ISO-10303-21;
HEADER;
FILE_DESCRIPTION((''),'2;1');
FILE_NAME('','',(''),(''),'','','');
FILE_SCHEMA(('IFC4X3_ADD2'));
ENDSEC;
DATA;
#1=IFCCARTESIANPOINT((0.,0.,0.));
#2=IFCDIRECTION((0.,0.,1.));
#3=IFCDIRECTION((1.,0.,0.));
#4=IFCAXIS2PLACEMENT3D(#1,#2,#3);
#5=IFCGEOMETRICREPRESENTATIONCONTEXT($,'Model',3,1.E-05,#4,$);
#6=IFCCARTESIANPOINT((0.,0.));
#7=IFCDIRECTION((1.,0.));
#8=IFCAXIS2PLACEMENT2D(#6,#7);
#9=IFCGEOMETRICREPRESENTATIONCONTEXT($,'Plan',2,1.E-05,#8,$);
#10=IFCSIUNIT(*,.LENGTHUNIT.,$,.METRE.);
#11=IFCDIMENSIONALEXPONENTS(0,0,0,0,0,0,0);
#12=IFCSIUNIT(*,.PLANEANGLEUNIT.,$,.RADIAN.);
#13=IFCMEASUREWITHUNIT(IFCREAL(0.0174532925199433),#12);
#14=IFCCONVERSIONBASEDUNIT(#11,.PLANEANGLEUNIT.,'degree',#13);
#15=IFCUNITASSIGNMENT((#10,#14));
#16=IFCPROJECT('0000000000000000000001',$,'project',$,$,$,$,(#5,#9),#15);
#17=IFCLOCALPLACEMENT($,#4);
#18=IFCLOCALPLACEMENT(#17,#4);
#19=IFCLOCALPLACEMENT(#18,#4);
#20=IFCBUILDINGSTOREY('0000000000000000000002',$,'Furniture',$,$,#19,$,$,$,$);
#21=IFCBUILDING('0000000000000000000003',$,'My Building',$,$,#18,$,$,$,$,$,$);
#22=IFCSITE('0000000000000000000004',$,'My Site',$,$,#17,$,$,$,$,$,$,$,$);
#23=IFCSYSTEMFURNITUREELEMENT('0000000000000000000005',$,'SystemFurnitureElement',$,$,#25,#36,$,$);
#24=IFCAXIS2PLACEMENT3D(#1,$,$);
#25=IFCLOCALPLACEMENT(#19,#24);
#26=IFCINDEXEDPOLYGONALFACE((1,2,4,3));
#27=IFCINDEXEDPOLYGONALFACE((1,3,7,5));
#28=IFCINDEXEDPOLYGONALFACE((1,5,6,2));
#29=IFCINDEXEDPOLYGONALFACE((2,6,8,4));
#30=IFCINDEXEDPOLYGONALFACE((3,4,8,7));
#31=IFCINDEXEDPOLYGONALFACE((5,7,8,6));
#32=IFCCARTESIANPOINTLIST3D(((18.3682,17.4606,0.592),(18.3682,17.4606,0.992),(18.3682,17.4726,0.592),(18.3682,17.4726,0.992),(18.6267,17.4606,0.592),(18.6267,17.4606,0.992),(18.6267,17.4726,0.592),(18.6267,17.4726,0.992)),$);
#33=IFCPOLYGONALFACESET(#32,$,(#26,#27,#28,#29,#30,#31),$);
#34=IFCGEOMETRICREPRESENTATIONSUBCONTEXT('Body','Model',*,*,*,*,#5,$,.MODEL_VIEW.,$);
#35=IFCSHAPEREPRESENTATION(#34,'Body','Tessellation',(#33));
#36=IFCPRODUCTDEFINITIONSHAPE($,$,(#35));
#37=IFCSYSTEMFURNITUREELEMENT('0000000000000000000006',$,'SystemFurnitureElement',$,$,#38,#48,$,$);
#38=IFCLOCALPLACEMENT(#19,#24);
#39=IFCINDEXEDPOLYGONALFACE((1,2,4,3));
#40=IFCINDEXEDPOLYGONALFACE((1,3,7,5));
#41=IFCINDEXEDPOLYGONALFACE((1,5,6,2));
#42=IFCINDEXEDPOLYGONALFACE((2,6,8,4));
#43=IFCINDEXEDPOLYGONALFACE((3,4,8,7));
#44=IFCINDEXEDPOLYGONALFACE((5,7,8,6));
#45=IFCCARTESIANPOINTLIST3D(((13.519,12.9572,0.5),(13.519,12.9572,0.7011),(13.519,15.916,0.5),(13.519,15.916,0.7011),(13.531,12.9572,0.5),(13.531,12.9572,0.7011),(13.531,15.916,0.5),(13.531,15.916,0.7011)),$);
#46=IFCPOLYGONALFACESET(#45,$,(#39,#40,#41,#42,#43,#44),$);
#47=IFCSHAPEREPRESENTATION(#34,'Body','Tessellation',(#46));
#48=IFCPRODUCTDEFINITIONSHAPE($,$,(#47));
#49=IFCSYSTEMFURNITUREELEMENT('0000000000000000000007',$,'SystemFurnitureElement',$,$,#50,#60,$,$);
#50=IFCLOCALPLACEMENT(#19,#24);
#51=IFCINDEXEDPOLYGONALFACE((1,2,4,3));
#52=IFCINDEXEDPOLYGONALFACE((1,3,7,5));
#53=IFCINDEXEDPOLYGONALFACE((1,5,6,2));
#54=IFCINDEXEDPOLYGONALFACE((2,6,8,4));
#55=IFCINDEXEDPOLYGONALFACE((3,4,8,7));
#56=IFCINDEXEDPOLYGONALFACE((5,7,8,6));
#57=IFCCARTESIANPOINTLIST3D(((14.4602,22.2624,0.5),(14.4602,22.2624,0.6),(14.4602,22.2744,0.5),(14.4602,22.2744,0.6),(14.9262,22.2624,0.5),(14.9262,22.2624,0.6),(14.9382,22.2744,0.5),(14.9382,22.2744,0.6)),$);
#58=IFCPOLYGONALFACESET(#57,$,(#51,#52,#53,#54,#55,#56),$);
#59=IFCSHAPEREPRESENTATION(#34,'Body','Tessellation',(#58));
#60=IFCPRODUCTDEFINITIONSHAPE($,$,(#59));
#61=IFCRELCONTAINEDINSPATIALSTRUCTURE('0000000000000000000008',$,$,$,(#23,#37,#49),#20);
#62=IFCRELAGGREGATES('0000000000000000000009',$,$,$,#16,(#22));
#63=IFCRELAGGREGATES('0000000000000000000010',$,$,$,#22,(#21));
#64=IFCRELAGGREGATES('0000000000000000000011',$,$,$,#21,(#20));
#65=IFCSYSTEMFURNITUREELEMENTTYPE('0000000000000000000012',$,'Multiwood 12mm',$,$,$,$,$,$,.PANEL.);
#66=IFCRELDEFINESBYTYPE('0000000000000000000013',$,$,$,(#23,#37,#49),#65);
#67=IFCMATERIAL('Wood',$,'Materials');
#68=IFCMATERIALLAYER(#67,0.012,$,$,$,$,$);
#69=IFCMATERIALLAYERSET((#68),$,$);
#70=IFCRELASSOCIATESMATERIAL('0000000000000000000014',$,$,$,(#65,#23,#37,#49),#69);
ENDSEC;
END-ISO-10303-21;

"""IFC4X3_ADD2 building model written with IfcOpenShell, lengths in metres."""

from ifc_helpers import new_model, entity, si_unit, converted_unit, frame, origin_with_axes, origin_2d_with_axis, place, context, subcontext, project, spatial, line, indexed_curve, outline, extrude, material, layer, layer_set, layer_usage, type_object, element, save


model = new_model("IFC4X3_ADD2")

# Units and contexts
model_context = context("Model", 3, precision=1e-05, world=origin_with_axes())
plan_context = context("Plan", 2, precision=1e-05, world=origin_2d_with_axis())
body_context = subcontext(model_context, "Body", "Model", "MODEL_VIEW")
ifc_project = project(units=[si_unit("LENGTHUNIT", "METRE"), converted_unit("PLANEANGLEUNIT", "degree", entity("IfcReal", 0.0174532925199433), si_unit("PLANEANGLEUNIT", "RADIAN"), dimensions=[0, 0, 0, 0, 0, 0, 0])], contexts=[model_context, plan_context])

# Site, building, storey
site_placement = place(None, origin_with_axes())
site = spatial("IfcSite", under=ifc_project, at=site_placement, Name="My Site")
building_placement = place(site_placement, origin_with_axes())
building = spatial("IfcBuilding", under=site, at=building_placement, Name="My Building")
storey_placement = place(building_placement, origin_with_axes())
storey = spatial("IfcBuildingStorey", under=building, at=storey_placement, Name="Furniture")

# System furniture element
ifc_material = material(Name="Wood", Category="Materials")
ifc_layer_1 = layer(ifc_material, 0.012)
ifc_layer_set_1 = layer_set([ifc_layer_1])
system_furniture_element_type_1 = type_object("IfcSystemFurnitureElementType", Name="Multiwood 12mm", PredefinedType="PANEL", material=ifc_layer_set_1)
ifc_layer_usage_1 = layer_usage(ifc_layer_set_1, "AXIS2", "POSITIVE", 0.0)
system_furniture_element_1_placement = place(storey_placement, frame((18.6267, 17.4726, 0.592), z_axis=(0.0, 0.0, 1.0), x_axis=(-1.0, 0.000001, 0.0)))
element("IfcSystemFurnitureElement", 1, at=system_furniture_element_1_placement, inside=storey, type_object=system_furniture_element_type_1, material=ifc_layer_usage_1, Name="SystemFurnitureElement", context=body_context, shape_type="SweptSolid", body=[
    extrude(outline(indexed_curve([(0.0, 0.0), (0.0, 0.012), (0.2584, 0.012), (0.2584, 0.0)], segments=[line(1, 2, 3, 4, 1)])), origin_with_axes(), (0.0, 0.0, 1.0), 0.4),
])

# System furniture element
ifc_layer_usage_2 = layer_usage(ifc_layer_set_1, "AXIS2", "POSITIVE", 0.0)
system_furniture_element_2_placement = place(storey_placement, frame((13.531, 12.9572, 0.5), z_axis=(0.0, 0.0, 1.0), x_axis=(0.000002, 1.0, 0.0)))
element("IfcSystemFurnitureElement", 2, at=system_furniture_element_2_placement, inside=storey, type_object=system_furniture_element_type_1, material=ifc_layer_usage_2, Name="SystemFurnitureElement", context=body_context, shape_type="SweptSolid", body=[
    extrude(outline(indexed_curve([(0.0, 0.0), (0.0, 0.012), (2.9588, 0.012), (2.9588, 0.0)], segments=[line(1, 2, 3, 4, 1)])), origin_with_axes(), (0.0, 0.0, 1.0), 0.2011),
])

# System furniture element
ifc_layer_usage_3 = layer_usage(ifc_layer_set_1, "AXIS2", "NEGATIVE", 0.0)
system_furniture_element_3_placement = place(storey_placement, frame((14.9382, 22.2624, 0.5), z_axis=(0.0, 0.0, 1.0), x_axis=(-1.0, 0.000001, 0.0)))
element("IfcSystemFurnitureElement", 3, at=system_furniture_element_3_placement, inside=storey, type_object=system_furniture_element_type_1, material=ifc_layer_usage_3, Name="SystemFurnitureElement", context=body_context, shape_type="SweptSolid", body=[
    extrude(outline(indexed_curve([(0.0, -0.012), (0.012, 0.0), (0.478, 0.0), (0.478, -0.012)], segments=[line(1, 2, 3, 4, 1)])), origin_with_axes(), (0.0, 0.0, 1.0), 0.1),
])

save(model, "model.ifc")
